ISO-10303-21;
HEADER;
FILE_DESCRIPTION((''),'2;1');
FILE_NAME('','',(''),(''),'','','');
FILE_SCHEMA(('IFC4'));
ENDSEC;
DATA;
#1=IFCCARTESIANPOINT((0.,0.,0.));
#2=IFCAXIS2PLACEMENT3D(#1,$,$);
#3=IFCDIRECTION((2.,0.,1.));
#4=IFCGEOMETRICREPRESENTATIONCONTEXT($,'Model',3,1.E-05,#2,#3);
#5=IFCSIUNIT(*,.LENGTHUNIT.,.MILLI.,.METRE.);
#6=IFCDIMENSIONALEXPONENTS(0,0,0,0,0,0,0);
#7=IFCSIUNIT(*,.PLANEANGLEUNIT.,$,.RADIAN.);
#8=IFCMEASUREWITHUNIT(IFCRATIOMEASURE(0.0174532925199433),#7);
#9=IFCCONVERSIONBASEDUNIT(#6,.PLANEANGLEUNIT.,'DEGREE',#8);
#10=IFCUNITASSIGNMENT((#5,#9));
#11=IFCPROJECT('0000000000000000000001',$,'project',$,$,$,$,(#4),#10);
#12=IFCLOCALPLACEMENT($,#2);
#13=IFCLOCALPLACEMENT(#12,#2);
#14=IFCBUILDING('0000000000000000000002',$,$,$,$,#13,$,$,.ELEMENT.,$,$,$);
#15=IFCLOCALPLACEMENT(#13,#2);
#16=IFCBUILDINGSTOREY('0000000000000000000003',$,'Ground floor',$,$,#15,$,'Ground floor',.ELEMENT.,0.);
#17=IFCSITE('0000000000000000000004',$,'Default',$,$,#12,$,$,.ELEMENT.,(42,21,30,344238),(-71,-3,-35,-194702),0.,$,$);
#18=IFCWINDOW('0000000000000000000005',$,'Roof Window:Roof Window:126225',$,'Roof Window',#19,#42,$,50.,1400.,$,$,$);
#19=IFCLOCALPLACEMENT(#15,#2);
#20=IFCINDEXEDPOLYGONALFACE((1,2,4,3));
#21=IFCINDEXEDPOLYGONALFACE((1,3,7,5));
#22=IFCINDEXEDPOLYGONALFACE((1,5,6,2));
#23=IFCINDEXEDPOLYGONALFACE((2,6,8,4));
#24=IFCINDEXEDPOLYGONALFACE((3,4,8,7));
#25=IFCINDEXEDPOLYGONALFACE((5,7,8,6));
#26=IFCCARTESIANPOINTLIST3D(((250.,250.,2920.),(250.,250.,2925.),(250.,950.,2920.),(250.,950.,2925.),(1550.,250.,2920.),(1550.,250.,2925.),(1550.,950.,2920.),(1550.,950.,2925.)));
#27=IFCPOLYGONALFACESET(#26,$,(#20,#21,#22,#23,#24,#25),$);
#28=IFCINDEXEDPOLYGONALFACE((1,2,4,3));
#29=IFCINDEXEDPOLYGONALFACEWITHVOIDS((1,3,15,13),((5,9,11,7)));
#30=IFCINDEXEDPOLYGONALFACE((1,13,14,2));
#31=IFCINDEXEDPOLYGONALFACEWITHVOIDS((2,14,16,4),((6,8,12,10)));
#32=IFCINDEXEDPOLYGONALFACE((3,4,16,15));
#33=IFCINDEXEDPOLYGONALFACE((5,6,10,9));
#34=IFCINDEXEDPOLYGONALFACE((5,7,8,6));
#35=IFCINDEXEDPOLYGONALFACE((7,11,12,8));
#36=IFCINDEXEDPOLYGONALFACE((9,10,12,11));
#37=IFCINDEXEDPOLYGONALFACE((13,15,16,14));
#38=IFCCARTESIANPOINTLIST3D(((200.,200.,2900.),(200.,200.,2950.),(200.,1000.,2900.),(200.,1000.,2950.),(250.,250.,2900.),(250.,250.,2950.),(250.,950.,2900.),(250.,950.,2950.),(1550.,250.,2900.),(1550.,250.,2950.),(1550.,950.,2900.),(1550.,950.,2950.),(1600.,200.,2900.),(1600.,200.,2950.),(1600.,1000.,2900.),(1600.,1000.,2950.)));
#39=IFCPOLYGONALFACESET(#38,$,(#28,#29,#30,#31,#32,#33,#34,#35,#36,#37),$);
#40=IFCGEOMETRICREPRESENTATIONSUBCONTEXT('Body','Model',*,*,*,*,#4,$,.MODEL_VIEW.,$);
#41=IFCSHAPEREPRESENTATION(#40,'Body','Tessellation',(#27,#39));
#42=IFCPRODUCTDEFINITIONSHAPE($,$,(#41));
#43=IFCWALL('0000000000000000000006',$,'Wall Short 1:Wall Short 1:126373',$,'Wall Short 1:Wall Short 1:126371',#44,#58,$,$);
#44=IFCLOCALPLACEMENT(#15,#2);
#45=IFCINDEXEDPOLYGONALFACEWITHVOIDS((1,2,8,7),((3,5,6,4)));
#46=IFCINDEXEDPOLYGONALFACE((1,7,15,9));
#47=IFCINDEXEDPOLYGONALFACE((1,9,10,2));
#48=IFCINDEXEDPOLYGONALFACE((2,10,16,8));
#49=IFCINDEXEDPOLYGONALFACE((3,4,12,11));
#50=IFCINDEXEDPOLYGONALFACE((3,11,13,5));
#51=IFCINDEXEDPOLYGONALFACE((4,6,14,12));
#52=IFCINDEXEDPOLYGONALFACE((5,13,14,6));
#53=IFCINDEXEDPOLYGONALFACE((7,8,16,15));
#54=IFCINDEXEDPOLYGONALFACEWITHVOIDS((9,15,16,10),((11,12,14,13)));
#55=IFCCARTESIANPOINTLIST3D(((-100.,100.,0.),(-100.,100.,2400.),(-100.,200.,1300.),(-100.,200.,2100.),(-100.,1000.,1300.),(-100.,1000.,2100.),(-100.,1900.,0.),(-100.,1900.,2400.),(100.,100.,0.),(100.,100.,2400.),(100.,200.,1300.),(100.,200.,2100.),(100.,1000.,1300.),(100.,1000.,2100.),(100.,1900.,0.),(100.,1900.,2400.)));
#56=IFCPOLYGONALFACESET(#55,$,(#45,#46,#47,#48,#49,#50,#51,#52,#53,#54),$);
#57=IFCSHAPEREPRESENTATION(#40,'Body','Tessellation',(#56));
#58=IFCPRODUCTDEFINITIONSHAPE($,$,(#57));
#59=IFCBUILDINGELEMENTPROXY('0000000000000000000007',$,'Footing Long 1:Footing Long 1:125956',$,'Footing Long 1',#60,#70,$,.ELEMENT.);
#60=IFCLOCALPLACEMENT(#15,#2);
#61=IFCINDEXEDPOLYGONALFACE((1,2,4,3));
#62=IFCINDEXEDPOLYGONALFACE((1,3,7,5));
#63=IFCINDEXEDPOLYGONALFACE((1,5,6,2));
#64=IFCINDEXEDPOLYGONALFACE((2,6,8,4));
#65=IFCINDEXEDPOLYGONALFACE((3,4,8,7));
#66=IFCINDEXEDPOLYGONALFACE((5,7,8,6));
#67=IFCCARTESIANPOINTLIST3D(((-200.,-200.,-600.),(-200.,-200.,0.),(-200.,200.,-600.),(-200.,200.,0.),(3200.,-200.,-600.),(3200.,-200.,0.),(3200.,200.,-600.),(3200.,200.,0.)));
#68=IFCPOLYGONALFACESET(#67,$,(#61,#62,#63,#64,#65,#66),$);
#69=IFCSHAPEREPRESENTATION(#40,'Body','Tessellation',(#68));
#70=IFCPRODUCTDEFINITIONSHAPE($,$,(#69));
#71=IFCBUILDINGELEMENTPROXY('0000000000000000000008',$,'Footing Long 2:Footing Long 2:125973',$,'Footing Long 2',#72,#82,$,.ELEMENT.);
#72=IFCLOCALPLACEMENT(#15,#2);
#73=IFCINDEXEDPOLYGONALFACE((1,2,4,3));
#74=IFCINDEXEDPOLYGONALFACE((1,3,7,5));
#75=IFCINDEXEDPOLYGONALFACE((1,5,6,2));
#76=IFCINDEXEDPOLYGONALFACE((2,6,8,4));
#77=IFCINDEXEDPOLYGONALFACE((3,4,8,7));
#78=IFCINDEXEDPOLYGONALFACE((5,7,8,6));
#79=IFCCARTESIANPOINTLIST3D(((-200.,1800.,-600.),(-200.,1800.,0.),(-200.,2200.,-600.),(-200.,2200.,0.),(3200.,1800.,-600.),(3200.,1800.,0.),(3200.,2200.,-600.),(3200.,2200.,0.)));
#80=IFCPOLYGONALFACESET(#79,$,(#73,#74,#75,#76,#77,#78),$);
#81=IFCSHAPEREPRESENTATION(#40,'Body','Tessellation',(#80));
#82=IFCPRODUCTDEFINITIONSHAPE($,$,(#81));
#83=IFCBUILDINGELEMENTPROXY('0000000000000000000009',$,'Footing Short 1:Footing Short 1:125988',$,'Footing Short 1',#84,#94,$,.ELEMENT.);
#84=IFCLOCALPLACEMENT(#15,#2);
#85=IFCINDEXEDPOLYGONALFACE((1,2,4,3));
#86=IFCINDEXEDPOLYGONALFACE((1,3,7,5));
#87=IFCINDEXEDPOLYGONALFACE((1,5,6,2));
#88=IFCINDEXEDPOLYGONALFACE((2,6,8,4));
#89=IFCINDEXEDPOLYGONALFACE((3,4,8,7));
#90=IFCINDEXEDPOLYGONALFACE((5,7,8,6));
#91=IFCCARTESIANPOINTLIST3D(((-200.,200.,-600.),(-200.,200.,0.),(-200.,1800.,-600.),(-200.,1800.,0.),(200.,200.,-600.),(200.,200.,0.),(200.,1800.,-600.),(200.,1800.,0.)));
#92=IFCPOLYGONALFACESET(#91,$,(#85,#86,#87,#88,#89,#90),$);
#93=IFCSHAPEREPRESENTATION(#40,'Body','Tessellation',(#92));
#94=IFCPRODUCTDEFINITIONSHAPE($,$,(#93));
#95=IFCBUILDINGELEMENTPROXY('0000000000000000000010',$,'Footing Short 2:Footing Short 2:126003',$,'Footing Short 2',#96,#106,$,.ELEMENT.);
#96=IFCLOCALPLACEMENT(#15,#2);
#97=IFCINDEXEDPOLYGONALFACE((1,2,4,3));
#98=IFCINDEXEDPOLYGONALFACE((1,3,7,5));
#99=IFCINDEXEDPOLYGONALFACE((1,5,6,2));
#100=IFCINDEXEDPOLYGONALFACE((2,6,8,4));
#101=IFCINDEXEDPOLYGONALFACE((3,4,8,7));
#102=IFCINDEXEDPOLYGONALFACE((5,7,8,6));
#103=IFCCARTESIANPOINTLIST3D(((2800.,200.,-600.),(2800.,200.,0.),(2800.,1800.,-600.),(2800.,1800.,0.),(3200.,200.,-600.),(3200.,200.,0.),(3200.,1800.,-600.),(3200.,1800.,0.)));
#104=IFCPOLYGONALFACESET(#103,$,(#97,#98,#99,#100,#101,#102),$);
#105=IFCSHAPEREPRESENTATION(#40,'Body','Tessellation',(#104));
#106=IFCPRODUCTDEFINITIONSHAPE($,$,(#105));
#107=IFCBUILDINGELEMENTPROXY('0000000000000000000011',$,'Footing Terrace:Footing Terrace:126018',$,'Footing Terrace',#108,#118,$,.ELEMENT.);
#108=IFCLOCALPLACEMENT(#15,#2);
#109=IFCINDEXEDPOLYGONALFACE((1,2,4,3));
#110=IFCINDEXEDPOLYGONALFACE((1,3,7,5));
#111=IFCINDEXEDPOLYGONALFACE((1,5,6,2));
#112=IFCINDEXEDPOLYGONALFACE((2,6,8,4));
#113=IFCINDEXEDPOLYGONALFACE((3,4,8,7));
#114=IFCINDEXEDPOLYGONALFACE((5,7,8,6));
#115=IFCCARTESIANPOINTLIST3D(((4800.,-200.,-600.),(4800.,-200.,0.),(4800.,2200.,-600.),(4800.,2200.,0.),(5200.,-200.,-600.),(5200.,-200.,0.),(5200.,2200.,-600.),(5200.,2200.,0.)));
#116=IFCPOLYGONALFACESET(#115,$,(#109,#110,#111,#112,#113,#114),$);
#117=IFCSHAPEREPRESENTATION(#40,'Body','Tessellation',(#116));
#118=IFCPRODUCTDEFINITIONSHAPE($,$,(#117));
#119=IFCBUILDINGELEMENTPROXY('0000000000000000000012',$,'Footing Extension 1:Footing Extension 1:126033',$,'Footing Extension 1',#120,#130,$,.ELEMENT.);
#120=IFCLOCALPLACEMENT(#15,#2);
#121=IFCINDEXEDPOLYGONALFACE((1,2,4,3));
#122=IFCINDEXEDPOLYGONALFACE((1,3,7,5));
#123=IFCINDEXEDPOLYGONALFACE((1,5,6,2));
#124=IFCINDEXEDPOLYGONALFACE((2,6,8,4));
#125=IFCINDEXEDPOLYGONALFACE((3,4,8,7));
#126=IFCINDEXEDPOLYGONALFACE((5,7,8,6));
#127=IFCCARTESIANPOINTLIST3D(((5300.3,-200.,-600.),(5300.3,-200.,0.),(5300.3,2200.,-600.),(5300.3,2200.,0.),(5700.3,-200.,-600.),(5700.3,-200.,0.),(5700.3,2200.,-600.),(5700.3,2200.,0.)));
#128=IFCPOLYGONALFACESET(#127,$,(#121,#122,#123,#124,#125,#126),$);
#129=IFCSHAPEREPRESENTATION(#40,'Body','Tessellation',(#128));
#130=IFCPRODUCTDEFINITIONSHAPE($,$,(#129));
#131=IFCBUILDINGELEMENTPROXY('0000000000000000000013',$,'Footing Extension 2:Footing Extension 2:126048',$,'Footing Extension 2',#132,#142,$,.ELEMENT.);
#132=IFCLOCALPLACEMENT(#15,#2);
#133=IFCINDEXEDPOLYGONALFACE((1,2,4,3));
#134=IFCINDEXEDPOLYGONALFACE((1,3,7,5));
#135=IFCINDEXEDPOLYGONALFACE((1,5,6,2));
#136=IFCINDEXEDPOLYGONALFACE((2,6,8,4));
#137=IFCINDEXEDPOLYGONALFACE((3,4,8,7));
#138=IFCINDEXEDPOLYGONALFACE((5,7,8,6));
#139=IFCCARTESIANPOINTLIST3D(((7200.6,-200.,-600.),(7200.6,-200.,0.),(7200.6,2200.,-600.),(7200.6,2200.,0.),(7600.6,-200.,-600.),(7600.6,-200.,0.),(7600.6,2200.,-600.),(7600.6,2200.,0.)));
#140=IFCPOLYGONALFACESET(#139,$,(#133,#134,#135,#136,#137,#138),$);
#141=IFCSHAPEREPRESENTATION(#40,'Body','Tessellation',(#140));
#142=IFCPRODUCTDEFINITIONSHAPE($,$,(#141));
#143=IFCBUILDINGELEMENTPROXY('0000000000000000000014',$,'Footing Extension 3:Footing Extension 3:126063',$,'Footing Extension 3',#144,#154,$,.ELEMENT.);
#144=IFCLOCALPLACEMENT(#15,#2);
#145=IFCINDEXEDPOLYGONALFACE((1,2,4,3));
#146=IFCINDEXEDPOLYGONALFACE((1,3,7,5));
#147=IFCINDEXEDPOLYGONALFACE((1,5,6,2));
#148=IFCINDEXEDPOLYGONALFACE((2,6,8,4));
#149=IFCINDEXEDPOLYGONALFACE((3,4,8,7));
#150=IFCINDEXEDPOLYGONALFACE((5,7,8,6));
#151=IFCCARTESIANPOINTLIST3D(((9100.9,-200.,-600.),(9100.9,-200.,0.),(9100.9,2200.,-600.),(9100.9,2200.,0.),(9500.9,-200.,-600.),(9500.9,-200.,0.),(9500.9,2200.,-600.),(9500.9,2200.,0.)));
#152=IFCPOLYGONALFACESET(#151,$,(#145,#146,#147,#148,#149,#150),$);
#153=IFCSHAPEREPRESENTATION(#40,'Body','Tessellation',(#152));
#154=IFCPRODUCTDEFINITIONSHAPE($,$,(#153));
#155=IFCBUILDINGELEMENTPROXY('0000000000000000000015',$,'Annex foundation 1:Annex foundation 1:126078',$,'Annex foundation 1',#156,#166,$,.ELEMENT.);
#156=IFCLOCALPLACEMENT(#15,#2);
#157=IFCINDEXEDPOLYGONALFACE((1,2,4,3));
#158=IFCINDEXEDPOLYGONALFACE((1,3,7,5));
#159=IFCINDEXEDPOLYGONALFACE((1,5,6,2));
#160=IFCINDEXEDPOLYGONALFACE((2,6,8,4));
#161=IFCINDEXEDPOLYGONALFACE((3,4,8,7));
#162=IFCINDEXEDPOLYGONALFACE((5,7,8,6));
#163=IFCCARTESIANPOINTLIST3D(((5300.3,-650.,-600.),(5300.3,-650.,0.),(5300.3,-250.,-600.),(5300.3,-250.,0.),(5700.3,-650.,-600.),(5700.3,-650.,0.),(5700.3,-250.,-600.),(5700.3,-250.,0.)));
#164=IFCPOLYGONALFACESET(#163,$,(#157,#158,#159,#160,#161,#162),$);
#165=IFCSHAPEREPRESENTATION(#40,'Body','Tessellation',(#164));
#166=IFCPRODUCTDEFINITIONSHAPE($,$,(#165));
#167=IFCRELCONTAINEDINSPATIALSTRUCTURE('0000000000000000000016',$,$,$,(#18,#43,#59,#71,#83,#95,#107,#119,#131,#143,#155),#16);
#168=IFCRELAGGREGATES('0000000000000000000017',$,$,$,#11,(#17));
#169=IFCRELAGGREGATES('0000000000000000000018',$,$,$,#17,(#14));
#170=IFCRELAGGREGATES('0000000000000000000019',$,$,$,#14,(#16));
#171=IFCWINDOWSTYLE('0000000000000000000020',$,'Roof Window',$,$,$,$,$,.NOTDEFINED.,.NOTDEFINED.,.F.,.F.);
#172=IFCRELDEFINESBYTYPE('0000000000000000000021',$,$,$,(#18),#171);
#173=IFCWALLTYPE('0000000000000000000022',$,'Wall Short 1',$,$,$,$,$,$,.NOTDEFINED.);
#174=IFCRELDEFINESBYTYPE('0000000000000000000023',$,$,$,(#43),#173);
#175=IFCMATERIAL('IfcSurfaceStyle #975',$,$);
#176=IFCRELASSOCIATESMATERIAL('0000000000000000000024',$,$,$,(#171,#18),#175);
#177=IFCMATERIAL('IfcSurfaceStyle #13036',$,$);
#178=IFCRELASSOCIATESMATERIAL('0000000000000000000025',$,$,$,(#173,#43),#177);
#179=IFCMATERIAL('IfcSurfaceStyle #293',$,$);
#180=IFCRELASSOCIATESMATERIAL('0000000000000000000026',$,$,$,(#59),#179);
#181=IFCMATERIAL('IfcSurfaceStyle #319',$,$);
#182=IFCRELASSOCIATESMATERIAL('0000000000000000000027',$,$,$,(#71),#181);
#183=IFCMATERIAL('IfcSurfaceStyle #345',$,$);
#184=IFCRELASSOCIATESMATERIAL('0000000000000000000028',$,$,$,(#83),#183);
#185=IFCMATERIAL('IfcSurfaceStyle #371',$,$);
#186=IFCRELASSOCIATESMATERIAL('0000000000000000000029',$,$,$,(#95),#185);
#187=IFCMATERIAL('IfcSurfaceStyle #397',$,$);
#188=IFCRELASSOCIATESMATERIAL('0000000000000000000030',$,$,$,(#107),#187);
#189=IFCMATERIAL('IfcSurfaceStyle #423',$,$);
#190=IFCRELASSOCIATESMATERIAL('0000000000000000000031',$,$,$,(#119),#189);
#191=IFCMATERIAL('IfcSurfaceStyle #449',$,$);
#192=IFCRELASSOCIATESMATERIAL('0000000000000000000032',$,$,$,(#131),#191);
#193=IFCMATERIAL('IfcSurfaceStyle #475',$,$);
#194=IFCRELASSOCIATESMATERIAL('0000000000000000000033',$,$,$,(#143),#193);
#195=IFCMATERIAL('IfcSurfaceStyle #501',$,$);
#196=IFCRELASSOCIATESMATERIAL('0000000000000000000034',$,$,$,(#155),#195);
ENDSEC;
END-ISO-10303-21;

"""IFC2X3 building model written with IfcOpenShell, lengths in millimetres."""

from ifc_helpers import new_model, entity, si_unit, converted_unit, direction, frame, frame_2d, origin, origin_2d_with_axis, place, context, subcontext, project, spatial, polyline, rectangle, outline, extrude, source, transform, mapped, material, type_object, type_shapes, element, save


model = new_model("IFC2X3")

# Units and contexts
model_context = context("Model", 3, precision=1e-05, world=origin(), true_north=direction((2.0, 0.0, 1.0)))
body_context = subcontext(model_context, "Body", "Model", "MODEL_VIEW")
ifc_project = project(units=[si_unit("LENGTHUNIT", "METRE", prefix="MILLI"), converted_unit("PLANEANGLEUNIT", "DEGREE", entity("IfcRatioMeasure", 0.0174532925199433), si_unit("PLANEANGLEUNIT", "RADIAN"), dimensions=[0, 0, 0, 0, 0, 0, 0])], contexts=[model_context])

# Site, building, storey
site_placement = place(None, origin())
site = spatial("IfcSite", under=ifc_project, at=site_placement, Name="Default", CompositionType="ELEMENT", RefLatitude=(42, 21, 30, 344238), RefLongitude=(-71, -3, -35, -194702), RefElevation=0.0)
building_placement = place(site_placement, origin())
building = spatial("IfcBuilding", under=site, at=building_placement, CompositionType="ELEMENT")
storey_placement = place(building_placement, origin())
storey = spatial("IfcBuildingStorey", under=building, at=storey_placement, Name="Ground floor", LongName="Ground floor", CompositionType="ELEMENT", Elevation=0.0)

# Window
ifc_material_1 = material(Name="IfcSurfaceStyle #975")
window_style = type_object("IfcWindowStyle", Name="Roof Window", ConstructionType="NOTDEFINED", OperationType="NOTDEFINED", ParameterTakesPrecedence=False, Sizeable=False, material=ifc_material_1)
shared_shape_1 = source(origin(), body_context, "Body", "SweptSolid", [
    extrude(rectangle(XDim=1300.0, YDim=700.0, at=origin_2d_with_axis()), frame((900.0, 600.0, 2920.0), z_axis=(0.0, 0.0, 1.0), x_axis=(-1.0, 0.0, 0.0)), (0.0, 0.0, 1.0), 5.0),
    extrude(outline(polyline([(-700.0, -400.0), (700.0, -400.0), (700.0, 400.0), (-700.0, 400.0), (-700.0, -400.0)]), holes=[polyline([(650.0, -350.0), (-650.0, -350.0), (-650.0, 350.0), (650.0, 350.0), (650.0, -350.0)])]), frame((900.0, 600.0, 2900.0), z_axis=(0.0, 0.0, 1.0), x_axis=(-1.0, 0.0, 0.0)), (0.0, 0.0, 1.0), 50.0),
])
type_shapes(window_style, [shared_shape_1])
window_placement = place(storey_placement, origin())
element("IfcWindow", 1, at=window_placement, inside=storey, type_object=window_style, material=ifc_material_1, Name="Roof Window:Roof Window:126225", ObjectType="Roof Window", OverallHeight=50.0, OverallWidth=1400.0, context=body_context, shape_type="MappedRepresentation", body=[
    mapped(shared_shape_1, transform((0.0, 0.0, 0.0), scale=1.0)),
])

# Wall, opening
ifc_material_2 = material(Name="IfcSurfaceStyle #13036")
wall_type = type_object("IfcWallType", Name="Wall Short 1", PredefinedType="NOTDEFINED", material=ifc_material_2)
wall_placement = place(storey_placement, frame((-100.0, 100.0, 0.0), z_axis=(0.0, 0.0, 1.0), x_axis=(0.0, 1.0, 0.0)))
wall = element("IfcWall", 2, at=wall_placement, inside=storey, type_object=wall_type, material=ifc_material_2, Name="Wall Short 1:Wall Short 1:126373", ObjectType="Wall Short 1:Wall Short 1:126371", context=body_context, shape_type="SweptSolid", body=[
    extrude(rectangle(XDim=200.0, YDim=1800.0, at=origin_2d_with_axis()), frame((900.0, -100.0, 0.0), z_axis=(0.0, 0.0, 1.0), x_axis=(0.0, -1.0, 0.0)), (0.0, 0.0, 1.0), 2400.0),
])
opening_placement = place(storey_placement, frame((-100.0, 100.0, 0.0), z_axis=(0.0, 0.0, 1.0), x_axis=(0.0, 1.0, 0.0)))
element("IfcOpeningElement", 3, at=opening_placement, cuts=wall, ObjectType="Opening", context=body_context, shape_type="SweptSolid", body=[
    extrude(rectangle(XDim=800.0, YDim=800.0, at=frame_2d((0.0, 0.0), x_axis=(0.0, 1.0))), frame((500.0, -200.0, 1700.0), z_axis=(0.0, 1.0, 0.0), x_axis=(1.0, 0.0, 0.0)), (0.0, 0.0, 1.0), 200.0),
])

# Building element proxies
ifc_material_3 = material(Name="IfcSurfaceStyle #293")
shared_shape_2 = source(origin(), body_context, "Body", "SweptSolid", [
    extrude(rectangle(XDim=3400.0, YDim=400.0, at=origin_2d_with_axis()), frame((1500.0, 0.0, -600.0), z_axis=(0.0, 0.0, 1.0), x_axis=(-1.0, 0.0, 0.0)), (0.0, 0.0, 1.0), 600.0),
])
proxy_1_placement = place(storey_placement, origin())
element("IfcBuildingElementProxy", 4, at=proxy_1_placement, inside=storey, material=ifc_material_3, Name="Footing Long 1:Footing Long 1:125956", ObjectType="Footing Long 1", CompositionType="ELEMENT", context=body_context, shape_type="MappedRepresentation", body=[
    mapped(shared_shape_2, transform((0.0, 0.0, 0.0), scale=1.0)),
])
ifc_material_4 = material(Name="IfcSurfaceStyle #319")
shared_shape_3 = source(origin(), body_context, "Body", "SweptSolid", [
    extrude(rectangle(XDim=3400.0, YDim=400.0, at=origin_2d_with_axis()), frame((1500.0, 2000.0, -600.0), z_axis=(0.0, 0.0, 1.0), x_axis=(-1.0, 0.0, 0.0)), (0.0, 0.0, 1.0), 600.0),
])
proxy_2_placement = place(storey_placement, origin())
element("IfcBuildingElementProxy", 5, at=proxy_2_placement, inside=storey, material=ifc_material_4, Name="Footing Long 2:Footing Long 2:125973", ObjectType="Footing Long 2", CompositionType="ELEMENT", context=body_context, shape_type="MappedRepresentation", body=[
    mapped(shared_shape_3, transform((0.0, 0.0, 0.0), scale=1.0)),
])
ifc_material_5 = material(Name="IfcSurfaceStyle #345")
shared_shape_4 = source(origin(), body_context, "Body", "SweptSolid", [
    extrude(rectangle(XDim=1600.0, YDim=400.0, at=origin_2d_with_axis()), frame((0.0, 1000.0, -600.0), z_axis=(0.0, 0.0, 1.0), x_axis=(0.0, -1.0, 0.0)), (0.0, 0.0, 1.0), 600.0),
])
proxy_3_placement = place(storey_placement, origin())
element("IfcBuildingElementProxy", 6, at=proxy_3_placement, inside=storey, material=ifc_material_5, Name="Footing Short 1:Footing Short 1:125988", ObjectType="Footing Short 1", CompositionType="ELEMENT", context=body_context, shape_type="MappedRepresentation", body=[
    mapped(shared_shape_4, transform((0.0, 0.0, 0.0), scale=1.0)),
])
ifc_material_6 = material(Name="IfcSurfaceStyle #371")
shared_shape_5 = source(origin(), body_context, "Body", "SweptSolid", [
    extrude(rectangle(XDim=1600.0, YDim=400.0, at=origin_2d_with_axis()), frame((3000.0, 1000.0, -600.0), z_axis=(0.0, 0.0, 1.0), x_axis=(0.0, -1.0, 0.0)), (0.0, 0.0, 1.0), 600.0),
])
proxy_4_placement = place(storey_placement, origin())
element("IfcBuildingElementProxy", 7, at=proxy_4_placement, inside=storey, material=ifc_material_6, Name="Footing Short 2:Footing Short 2:126003", ObjectType="Footing Short 2", CompositionType="ELEMENT", context=body_context, shape_type="MappedRepresentation", body=[
    mapped(shared_shape_5, transform((0.0, 0.0, 0.0), scale=1.0)),
])
ifc_material_7 = material(Name="IfcSurfaceStyle #397")
shared_shape_6 = source(origin(), body_context, "Body", "SweptSolid", [
    extrude(rectangle(XDim=2400.0, YDim=400.0, at=origin_2d_with_axis()), frame((5000.0, 1000.0, -600.0), z_axis=(0.0, 0.0, 1.0), x_axis=(0.0, -1.0, 0.0)), (0.0, 0.0, 1.0), 600.0),
])
proxy_5_placement = place(storey_placement, origin())
element("IfcBuildingElementProxy", 8, at=proxy_5_placement, inside=storey, material=ifc_material_7, Name="Footing Terrace:Footing Terrace:126018", ObjectType="Footing Terrace", CompositionType="ELEMENT", context=body_context, shape_type="MappedRepresentation", body=[
    mapped(shared_shape_6, transform((0.0, 0.0, 0.0), scale=1.0)),
])
ifc_material_8 = material(Name="IfcSurfaceStyle #423")
shared_shape_7 = source(origin(), body_context, "Body", "SweptSolid", [
    extrude(rectangle(XDim=2400.0, YDim=400.0, at=origin_2d_with_axis()), frame((5500.3, 1000.0, -600.0), z_axis=(0.0, 0.0, 1.0), x_axis=(0.0, -1.0, 0.0)), (0.0, 0.0, 1.0), 600.0),
])
proxy_6_placement = place(storey_placement, origin())
element("IfcBuildingElementProxy", 9, at=proxy_6_placement, inside=storey, material=ifc_material_8, Name="Footing Extension 1:Footing Extension 1:126033", ObjectType="Footing Extension 1", CompositionType="ELEMENT", context=body_context, shape_type="MappedRepresentation", body=[
    mapped(shared_shape_7, transform((0.0, 0.0, 0.0), scale=1.0)),
])
ifc_material_9 = material(Name="IfcSurfaceStyle #449")
shared_shape_8 = source(origin(), body_context, "Body", "SweptSolid", [
    extrude(rectangle(XDim=2400.0, YDim=400.0, at=origin_2d_with_axis()), frame((7400.6, 1000.0, -600.0), z_axis=(0.0, 0.0, 1.0), x_axis=(0.0, -1.0, 0.0)), (0.0, 0.0, 1.0), 600.0),
])
proxy_7_placement = place(storey_placement, origin())
element("IfcBuildingElementProxy", 10, at=proxy_7_placement, inside=storey, material=ifc_material_9, Name="Footing Extension 2:Footing Extension 2:126048", ObjectType="Footing Extension 2", CompositionType="ELEMENT", context=body_context, shape_type="MappedRepresentation", body=[
    mapped(shared_shape_8, transform((0.0, 0.0, 0.0), scale=1.0)),
])
ifc_material_10 = material(Name="IfcSurfaceStyle #475")
shared_shape_9 = source(origin(), body_context, "Body", "SweptSolid", [
    extrude(rectangle(XDim=2400.0, YDim=400.0, at=origin_2d_with_axis()), frame((9300.9, 1000.0, -600.0), z_axis=(0.0, 0.0, 1.0), x_axis=(0.0, -1.0, 0.0)), (0.0, 0.0, 1.0), 600.0),
])
proxy_8_placement = place(storey_placement, origin())
element("IfcBuildingElementProxy", 11, at=proxy_8_placement, inside=storey, material=ifc_material_10, Name="Footing Extension 3:Footing Extension 3:126063", ObjectType="Footing Extension 3", CompositionType="ELEMENT", context=body_context, shape_type="MappedRepresentation", body=[
    mapped(shared_shape_9, transform((0.0, 0.0, 0.0), scale=1.0)),
])
ifc_material_11 = material(Name="IfcSurfaceStyle #501")
shared_shape_10 = source(origin(), body_context, "Body", "SweptSolid", [
    extrude(rectangle(XDim=400.0, YDim=400.0, at=origin_2d_with_axis()), frame((5500.3, -450.0, -600.0), z_axis=(0.0, 0.0, 1.0), x_axis=(0.0, 1.0, 0.0)), (0.0, 0.0, 1.0), 600.0),
])
proxy_9_placement = place(storey_placement, origin())
element("IfcBuildingElementProxy", 12, at=proxy_9_placement, inside=storey, material=ifc_material_11, Name="Annex foundation 1:Annex foundation 1:126078", ObjectType="Annex foundation 1", CompositionType="ELEMENT", context=body_context, shape_type="MappedRepresentation", body=[
    mapped(shared_shape_10, transform((0.0, 0.0, 0.0), scale=1.0)),
])

save(model, "model.ifc")
